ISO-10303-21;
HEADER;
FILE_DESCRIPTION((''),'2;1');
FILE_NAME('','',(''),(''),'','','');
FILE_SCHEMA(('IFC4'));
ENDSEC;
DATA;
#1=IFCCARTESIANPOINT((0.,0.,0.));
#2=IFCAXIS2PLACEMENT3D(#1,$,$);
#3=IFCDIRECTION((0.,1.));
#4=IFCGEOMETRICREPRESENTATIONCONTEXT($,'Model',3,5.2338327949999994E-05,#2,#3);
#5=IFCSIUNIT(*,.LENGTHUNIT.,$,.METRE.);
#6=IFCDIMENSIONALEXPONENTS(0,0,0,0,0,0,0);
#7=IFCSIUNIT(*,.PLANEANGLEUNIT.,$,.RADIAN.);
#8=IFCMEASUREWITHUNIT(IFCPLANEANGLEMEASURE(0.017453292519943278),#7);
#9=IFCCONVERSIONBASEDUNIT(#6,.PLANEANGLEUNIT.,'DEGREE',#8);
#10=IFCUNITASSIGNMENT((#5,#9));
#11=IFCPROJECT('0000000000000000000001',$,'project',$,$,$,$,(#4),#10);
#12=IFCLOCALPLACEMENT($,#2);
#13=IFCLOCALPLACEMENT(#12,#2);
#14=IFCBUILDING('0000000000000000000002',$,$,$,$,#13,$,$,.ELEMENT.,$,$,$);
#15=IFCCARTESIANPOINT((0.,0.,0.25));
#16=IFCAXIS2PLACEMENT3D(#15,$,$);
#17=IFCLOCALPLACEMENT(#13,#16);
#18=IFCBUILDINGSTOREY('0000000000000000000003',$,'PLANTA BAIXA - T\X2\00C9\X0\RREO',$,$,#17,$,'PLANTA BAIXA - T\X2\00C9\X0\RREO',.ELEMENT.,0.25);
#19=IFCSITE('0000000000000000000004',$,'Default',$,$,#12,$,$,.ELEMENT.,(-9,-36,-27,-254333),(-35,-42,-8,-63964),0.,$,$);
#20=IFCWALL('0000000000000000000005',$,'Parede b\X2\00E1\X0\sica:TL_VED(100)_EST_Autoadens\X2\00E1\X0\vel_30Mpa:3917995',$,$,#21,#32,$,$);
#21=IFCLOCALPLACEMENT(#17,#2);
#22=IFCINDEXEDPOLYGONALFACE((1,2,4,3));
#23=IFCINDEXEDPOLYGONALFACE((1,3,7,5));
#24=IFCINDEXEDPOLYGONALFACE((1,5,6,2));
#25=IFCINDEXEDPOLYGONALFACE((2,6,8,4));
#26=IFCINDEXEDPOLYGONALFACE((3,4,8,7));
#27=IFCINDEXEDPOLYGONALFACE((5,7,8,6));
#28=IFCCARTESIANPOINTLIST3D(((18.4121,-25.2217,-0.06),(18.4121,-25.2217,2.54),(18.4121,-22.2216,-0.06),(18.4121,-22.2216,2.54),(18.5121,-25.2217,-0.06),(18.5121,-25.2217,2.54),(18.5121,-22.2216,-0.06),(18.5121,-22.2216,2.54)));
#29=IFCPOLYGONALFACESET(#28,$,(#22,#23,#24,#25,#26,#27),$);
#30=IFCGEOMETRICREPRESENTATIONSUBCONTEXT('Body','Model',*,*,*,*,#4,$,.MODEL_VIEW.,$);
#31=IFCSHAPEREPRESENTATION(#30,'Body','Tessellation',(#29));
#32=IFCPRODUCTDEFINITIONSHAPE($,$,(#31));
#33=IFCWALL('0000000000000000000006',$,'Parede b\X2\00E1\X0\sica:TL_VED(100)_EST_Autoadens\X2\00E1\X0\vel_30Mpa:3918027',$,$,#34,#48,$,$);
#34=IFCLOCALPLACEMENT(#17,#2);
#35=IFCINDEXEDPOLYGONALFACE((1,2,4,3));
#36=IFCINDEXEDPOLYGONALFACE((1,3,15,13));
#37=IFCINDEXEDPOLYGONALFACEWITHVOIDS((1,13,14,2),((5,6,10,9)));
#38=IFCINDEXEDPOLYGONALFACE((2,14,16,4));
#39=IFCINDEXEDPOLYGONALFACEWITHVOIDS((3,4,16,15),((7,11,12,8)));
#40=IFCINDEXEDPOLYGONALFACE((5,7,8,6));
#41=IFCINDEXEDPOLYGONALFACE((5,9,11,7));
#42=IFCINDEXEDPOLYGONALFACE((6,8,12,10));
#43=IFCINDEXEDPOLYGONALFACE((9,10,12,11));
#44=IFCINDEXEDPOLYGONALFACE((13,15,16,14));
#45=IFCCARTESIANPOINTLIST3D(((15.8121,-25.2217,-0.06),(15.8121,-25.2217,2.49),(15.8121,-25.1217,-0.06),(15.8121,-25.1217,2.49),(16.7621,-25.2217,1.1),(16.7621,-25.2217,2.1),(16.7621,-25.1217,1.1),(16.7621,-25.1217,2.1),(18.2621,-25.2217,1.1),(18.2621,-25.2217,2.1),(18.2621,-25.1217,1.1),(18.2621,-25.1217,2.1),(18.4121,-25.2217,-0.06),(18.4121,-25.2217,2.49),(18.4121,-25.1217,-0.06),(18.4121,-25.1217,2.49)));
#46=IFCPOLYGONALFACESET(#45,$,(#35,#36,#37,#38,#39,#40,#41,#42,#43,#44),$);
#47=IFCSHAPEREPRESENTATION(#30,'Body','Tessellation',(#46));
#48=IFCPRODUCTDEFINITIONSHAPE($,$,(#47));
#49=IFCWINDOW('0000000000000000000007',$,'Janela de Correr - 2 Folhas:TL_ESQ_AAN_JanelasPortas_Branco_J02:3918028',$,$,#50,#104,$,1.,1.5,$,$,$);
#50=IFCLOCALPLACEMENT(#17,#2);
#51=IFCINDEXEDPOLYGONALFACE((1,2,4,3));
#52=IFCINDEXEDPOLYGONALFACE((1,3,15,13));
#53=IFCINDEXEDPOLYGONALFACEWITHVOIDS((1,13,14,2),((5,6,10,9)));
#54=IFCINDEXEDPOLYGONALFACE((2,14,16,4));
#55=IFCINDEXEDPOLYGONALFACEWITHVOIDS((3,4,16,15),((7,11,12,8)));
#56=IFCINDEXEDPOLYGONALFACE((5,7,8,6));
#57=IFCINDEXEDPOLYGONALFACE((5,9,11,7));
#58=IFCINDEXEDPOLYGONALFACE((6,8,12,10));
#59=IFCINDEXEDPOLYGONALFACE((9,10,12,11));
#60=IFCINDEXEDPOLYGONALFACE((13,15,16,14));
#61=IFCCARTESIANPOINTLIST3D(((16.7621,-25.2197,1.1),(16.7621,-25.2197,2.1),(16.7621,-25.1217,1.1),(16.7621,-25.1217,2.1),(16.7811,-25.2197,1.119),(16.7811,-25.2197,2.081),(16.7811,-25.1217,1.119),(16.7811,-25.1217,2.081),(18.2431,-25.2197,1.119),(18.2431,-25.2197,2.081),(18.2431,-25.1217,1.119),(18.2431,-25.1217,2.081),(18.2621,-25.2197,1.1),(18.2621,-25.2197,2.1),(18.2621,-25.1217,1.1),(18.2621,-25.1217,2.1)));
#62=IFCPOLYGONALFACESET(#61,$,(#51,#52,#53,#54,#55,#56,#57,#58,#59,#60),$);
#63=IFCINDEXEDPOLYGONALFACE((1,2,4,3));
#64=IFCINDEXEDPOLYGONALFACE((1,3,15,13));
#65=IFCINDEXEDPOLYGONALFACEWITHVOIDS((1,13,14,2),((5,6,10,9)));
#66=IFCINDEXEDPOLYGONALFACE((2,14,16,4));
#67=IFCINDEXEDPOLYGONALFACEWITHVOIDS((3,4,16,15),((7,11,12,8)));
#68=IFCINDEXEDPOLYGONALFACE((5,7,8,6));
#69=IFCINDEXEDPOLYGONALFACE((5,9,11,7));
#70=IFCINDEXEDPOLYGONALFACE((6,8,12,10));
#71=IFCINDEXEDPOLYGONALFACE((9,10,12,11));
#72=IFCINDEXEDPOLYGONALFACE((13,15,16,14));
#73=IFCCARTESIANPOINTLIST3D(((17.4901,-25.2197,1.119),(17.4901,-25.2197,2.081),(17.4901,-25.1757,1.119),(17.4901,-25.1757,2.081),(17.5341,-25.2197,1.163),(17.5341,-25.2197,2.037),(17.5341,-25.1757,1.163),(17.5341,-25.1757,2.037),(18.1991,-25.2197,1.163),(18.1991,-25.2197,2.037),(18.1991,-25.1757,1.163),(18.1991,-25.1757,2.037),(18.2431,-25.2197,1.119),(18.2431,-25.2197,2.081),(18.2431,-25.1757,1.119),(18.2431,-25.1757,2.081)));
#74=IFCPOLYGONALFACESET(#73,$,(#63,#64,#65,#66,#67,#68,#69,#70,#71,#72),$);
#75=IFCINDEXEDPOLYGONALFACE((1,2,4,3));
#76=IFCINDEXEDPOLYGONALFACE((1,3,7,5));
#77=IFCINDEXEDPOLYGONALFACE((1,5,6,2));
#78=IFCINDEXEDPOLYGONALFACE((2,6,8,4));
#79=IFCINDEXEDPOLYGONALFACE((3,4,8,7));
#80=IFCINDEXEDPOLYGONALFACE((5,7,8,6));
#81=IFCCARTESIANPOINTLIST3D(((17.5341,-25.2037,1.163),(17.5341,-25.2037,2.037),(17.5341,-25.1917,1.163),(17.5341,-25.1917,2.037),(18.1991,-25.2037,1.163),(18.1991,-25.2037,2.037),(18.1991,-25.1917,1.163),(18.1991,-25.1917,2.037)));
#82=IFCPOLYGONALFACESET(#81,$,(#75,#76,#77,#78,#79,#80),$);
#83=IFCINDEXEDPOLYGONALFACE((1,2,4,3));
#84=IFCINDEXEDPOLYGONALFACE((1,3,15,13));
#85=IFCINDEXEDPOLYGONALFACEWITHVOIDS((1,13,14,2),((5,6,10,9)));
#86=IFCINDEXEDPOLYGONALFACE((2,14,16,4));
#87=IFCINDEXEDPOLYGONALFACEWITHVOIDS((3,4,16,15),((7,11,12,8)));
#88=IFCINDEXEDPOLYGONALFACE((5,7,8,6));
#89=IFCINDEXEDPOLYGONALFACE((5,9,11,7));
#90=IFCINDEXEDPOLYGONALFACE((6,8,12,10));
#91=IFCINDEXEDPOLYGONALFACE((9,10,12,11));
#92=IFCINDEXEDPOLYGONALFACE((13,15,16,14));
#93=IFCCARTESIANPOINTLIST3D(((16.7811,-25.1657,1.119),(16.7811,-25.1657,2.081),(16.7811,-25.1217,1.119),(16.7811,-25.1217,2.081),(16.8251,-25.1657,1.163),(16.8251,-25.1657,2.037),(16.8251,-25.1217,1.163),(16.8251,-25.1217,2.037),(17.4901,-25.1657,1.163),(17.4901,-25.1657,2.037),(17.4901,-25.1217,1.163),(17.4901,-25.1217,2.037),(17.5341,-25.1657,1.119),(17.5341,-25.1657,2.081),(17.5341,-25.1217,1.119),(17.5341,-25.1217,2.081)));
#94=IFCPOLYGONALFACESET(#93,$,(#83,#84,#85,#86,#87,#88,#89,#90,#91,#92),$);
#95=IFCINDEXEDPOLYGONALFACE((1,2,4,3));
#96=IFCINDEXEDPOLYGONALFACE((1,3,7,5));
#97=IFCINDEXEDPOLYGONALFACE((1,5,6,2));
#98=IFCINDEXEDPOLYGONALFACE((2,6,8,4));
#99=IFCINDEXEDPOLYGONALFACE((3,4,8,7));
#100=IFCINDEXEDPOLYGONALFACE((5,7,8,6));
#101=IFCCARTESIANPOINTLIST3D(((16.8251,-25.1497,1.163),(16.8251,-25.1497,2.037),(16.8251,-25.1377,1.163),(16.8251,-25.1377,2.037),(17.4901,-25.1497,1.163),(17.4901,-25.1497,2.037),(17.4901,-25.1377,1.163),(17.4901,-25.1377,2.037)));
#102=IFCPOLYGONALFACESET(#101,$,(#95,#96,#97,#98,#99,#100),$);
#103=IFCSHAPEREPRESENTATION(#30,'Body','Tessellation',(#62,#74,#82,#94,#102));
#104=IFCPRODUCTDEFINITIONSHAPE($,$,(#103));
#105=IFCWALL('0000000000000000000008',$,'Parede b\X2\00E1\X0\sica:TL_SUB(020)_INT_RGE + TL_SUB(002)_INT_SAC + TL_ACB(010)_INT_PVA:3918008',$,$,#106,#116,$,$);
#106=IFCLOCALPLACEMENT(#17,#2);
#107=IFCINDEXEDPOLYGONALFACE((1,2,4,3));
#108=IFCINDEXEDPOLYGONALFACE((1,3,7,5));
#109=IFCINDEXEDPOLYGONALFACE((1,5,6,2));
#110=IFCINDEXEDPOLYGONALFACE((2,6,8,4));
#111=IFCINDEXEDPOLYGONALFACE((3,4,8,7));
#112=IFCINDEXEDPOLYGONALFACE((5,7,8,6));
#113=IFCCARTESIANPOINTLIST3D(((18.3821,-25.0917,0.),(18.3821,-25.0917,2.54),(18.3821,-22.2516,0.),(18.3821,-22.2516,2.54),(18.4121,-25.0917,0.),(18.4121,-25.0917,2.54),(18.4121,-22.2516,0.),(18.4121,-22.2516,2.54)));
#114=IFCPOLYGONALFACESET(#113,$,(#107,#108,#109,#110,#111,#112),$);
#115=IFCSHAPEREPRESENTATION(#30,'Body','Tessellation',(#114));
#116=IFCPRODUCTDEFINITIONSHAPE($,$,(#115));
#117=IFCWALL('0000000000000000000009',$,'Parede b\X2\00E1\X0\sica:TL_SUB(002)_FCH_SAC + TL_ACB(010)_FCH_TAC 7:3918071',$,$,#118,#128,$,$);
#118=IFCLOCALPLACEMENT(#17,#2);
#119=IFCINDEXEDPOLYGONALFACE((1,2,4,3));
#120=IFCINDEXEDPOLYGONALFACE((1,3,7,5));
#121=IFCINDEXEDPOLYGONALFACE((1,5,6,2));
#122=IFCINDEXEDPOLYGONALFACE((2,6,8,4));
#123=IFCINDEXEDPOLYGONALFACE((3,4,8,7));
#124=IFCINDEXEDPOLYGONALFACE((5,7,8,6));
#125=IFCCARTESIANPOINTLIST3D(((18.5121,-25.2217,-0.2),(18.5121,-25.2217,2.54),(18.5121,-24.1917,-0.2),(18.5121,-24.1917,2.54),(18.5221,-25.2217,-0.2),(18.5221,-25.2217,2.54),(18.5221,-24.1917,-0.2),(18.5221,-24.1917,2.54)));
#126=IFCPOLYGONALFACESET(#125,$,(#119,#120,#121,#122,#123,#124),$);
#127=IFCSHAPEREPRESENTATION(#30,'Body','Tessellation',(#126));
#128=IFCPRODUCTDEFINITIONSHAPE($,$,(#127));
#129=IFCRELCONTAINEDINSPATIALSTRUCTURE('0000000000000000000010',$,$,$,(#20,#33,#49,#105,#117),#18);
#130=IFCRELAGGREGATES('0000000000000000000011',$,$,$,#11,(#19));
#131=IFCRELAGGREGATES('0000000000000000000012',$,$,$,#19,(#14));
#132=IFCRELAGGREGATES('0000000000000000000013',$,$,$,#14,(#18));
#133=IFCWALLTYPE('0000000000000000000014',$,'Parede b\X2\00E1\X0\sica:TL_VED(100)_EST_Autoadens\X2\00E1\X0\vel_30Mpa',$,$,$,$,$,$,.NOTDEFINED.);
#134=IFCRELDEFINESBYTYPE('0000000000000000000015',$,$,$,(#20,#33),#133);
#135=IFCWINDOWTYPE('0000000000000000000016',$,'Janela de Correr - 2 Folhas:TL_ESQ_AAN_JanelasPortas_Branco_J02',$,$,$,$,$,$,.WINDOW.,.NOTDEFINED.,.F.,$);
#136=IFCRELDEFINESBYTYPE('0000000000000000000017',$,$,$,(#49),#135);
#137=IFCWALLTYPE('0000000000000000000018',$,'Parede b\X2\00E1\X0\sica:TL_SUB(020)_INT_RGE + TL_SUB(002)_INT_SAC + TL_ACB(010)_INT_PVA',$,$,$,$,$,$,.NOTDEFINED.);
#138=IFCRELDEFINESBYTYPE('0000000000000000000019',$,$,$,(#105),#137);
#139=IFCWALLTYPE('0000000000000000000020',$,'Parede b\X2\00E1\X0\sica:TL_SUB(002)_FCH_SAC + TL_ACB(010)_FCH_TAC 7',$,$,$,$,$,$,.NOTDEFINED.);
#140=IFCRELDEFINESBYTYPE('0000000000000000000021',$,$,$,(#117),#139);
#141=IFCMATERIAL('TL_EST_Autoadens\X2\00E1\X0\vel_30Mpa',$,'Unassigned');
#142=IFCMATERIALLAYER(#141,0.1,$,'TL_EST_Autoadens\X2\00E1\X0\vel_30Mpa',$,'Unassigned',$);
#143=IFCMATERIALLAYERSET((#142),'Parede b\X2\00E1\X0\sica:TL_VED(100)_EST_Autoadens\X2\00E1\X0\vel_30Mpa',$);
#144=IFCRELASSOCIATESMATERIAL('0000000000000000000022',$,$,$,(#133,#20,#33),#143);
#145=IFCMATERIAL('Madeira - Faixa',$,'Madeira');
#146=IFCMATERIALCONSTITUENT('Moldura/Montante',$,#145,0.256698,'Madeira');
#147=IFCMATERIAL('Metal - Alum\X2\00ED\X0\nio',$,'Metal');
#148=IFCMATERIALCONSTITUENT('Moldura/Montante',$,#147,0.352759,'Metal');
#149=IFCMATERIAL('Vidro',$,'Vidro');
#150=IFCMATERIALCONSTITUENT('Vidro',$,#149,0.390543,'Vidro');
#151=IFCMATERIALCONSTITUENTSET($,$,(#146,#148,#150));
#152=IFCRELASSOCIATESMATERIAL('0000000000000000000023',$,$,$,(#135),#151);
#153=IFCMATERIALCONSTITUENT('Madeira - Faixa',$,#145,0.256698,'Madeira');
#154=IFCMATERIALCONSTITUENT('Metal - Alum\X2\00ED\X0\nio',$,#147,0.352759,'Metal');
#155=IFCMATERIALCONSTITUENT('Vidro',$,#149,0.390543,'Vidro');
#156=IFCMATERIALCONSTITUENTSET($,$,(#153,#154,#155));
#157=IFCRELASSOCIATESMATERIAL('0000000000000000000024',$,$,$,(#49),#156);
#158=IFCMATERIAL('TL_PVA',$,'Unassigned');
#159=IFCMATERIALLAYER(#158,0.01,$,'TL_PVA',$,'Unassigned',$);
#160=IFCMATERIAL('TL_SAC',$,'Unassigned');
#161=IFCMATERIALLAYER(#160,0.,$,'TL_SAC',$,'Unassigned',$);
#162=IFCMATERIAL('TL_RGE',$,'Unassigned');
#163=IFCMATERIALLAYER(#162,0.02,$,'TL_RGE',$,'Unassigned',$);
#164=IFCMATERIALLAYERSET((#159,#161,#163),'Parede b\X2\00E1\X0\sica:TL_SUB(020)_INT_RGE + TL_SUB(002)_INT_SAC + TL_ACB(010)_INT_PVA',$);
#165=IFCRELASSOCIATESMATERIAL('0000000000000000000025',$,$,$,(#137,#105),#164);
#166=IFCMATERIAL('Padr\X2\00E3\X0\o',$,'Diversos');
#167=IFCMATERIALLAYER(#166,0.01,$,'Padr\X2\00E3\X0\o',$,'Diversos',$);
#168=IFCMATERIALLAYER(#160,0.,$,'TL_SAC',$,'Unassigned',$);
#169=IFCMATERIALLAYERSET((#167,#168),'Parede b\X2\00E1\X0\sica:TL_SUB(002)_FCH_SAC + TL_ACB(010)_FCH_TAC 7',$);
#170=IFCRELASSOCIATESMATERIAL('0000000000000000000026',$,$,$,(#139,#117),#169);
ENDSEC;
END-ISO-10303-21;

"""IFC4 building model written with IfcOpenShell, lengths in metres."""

from ifc_helpers import new_model, entity, si_unit, converted_unit, direction, frame, frame_2d, origin, origin_2d_with_axis, place, context, subcontext, project, spatial, polyline, rectangle, outline, extrude, source, transform, mapped, material, layer, layer_set, layer_usage, constituent, constituent_set, type_object, type_shapes, element, fill, save


model = new_model("IFC4")

# Units and contexts
model_context = context("Model", 3, precision=5.2338327949999994e-05, world=origin(), true_north=direction((0.0, 1.0)))
body_context = subcontext(model_context, "Body", "Model", "MODEL_VIEW")
ifc_project = project(units=[si_unit("LENGTHUNIT", "METRE"), converted_unit("PLANEANGLEUNIT", "DEGREE", entity("IfcPlaneAngleMeasure", 0.017453292519943278), si_unit("PLANEANGLEUNIT", "RADIAN"), dimensions=[0, 0, 0, 0, 0, 0, 0])], contexts=[model_context])

# Site, building, storey
site_placement = place(None, frame((0.0, 0.0, 0.0)))
site = spatial("IfcSite", under=ifc_project, at=site_placement, Name="Default", CompositionType="ELEMENT", RefLatitude=(-9, -36, -27, -254333), RefLongitude=(-35, -42, -8, -63964), RefElevation=0.0)
building_placement = place(site_placement, origin())
building = spatial("IfcBuilding", under=site, at=building_placement, CompositionType="ELEMENT")
storey_placement = place(building_placement, frame((0.0, 0.0, 0.25)))
storey = spatial("IfcBuildingStorey", under=building, at=storey_placement, Name="PLANTA BAIXA - TÉRREO", LongName="PLANTA BAIXA - TÉRREO", CompositionType="ELEMENT", Elevation=0.25)

# Wall
ifc_material_1 = material(Name="TL_EST_Autoadensável_30Mpa", Category="Unassigned")
ifc_layer_1 = layer(ifc_material_1, 0.1, Name="TL_EST_Autoadensável_30Mpa", Category="Unassigned")
ifc_layer_set_1 = layer_set([ifc_layer_1], Name="Parede básica:TL_VED(100)_EST_Autoadensável_30Mpa")
ifc_layer_usage_1 = layer_usage(ifc_layer_set_1, "AXIS2", "NEGATIVE", 0.05)
wall_type_1 = type_object("IfcWallType", Name="Parede básica:TL_VED(100)_EST_Autoadensável_30Mpa", PredefinedType="NOTDEFINED", material=ifc_layer_set_1)
wall_1_placement = place(storey_placement, frame((18.4621, -25.2217, -0.06), z_axis=(0.0, 0.0, 1.0), x_axis=(0.0, 1.0, 0.0)))
element("IfcWall", 1, at=wall_1_placement, inside=storey, type_object=wall_type_1, material=ifc_layer_usage_1, Name="Parede básica:TL_VED(100)_EST_Autoadensável_30Mpa:3917995", context=body_context, shape_type="SweptSolid", body=[
    extrude(rectangle(XDim=3.0001, YDim=0.1, at=frame_2d((1.5001, 0.0), x_axis=(-1.0, 0.0))), origin(), (0.0, 0.0, 1.0), 2.6),
])

# Wall, opening, window
ifc_layer_usage_2 = layer_usage(ifc_layer_set_1, "AXIS2", "NEGATIVE", 0.05)
wall_2_placement = place(storey_placement, frame((18.4121, -25.1717, -0.06), z_axis=(0.0, 0.0, 1.0), x_axis=(-1.0, 0.0, 0.0)))
wall_2 = element("IfcWall", 2, at=wall_2_placement, inside=storey, type_object=wall_type_1, material=ifc_layer_usage_2, Name="Parede básica:TL_VED(100)_EST_Autoadensável_30Mpa:3918027", context=body_context, shape_type="SweptSolid", body=[
    extrude(rectangle(XDim=2.6, YDim=0.1, at=frame_2d((1.3, 0.0), x_axis=(-1.0, 0.0))), origin(), (0.0, 0.0, 1.0), 2.55),
])
opening_placement = place(wall_2_placement, frame((0.15, -0.05, 1.16)))
opening = element("IfcOpeningElement", 3, at=opening_placement, cuts=wall_2, PredefinedType="OPENING", context=body_context, shape_type="SweptSolid", body=[
    extrude(rectangle(XDim=1.0, YDim=1.5, at=frame_2d((0.5, 0.75), x_axis=(-1.0, 0.0))), frame((0.0, 0.0, 0.0), z_axis=(0.0, 1.0, 0.0), x_axis=(0.0, 0.0, 1.0)), (0.0, 0.0, 1.0), 0.1),
])
ifc_material_2 = material(Name="Madeira - Faixa", Category="Madeira")
ifc_constituent_1 = constituent(ifc_material_2, Name="Madeira - Faixa", Category="Madeira", fraction=0.256698)
ifc_material_3 = material(Name="Metal - Alumínio", Category="Metal")
ifc_constituent_2 = constituent(ifc_material_3, Name="Metal - Alumínio", Category="Metal", fraction=0.352759)
ifc_material_4 = material(Name="Vidro", Category="Vidro")
ifc_constituent_3 = constituent(ifc_material_4, Name="Vidro", Category="Vidro", fraction=0.390543)
ifc_constituent_set_1 = constituent_set(constituents=[ifc_constituent_1, ifc_constituent_2, ifc_constituent_3])
ifc_constituent_4 = constituent(ifc_material_2, Name="Moldura/Montante", Category="Madeira", fraction=0.256698)
ifc_constituent_5 = constituent(ifc_material_3, Name="Moldura/Montante", Category="Metal", fraction=0.352759)
ifc_constituent_6 = constituent(ifc_material_4, Name="Vidro", Category="Vidro", fraction=0.390543)
ifc_constituent_set_2 = constituent_set(constituents=[ifc_constituent_4, ifc_constituent_5, ifc_constituent_6])
window_type = type_object("IfcWindowType", Name="Janela de Correr - 2 Folhas:TL_ESQ_AAN_JanelasPortas_Branco_J02", ParameterTakesPrecedence=False, PartitioningType="NOTDEFINED", PredefinedType="WINDOW", material=ifc_constituent_set_2)
shared_shape_1 = source(origin(), body_context, "Body", "SweptSolid", [
    extrude(outline(polyline([(-0.75, -0.5), (0.75, -0.5), (0.75, 0.5), (-0.75, 0.5), (-0.75, -0.5)]), holes=[polyline([(-0.731, -0.481), (-0.731, 0.481), (0.731, 0.481), (0.731, -0.481), (-0.731, -0.481)])]), frame((0.75, 0.124, 0.5), z_axis=(0.0, -1.0, 0.0), x_axis=(-1.0, 0.0, 0.0)), (0.0, 0.0, 1.0), 0.098),
    extrude(outline(polyline([(-0.3765, -0.481), (0.3765, -0.481), (0.3765, 0.481), (-0.3765, 0.481), (-0.3765, -0.481)]), holes=[polyline([(-0.3325, -0.437), (-0.3325, 0.437), (0.3325, 0.437), (0.3325, -0.437), (-0.3325, -0.437)])]), frame((0.3955, 0.124, 0.5), z_axis=(0.0, -1.0, 0.0), x_axis=(-1.0, 0.0, 0.0)), (0.0, 0.0, 1.0), 0.044),
    extrude(rectangle(XDim=0.665, YDim=0.012, at=origin_2d_with_axis()), frame((0.3955, 0.102, 0.063), z_axis=(0.0, 0.0, 1.0), x_axis=(-1.0, 0.0, 0.0)), (0.0, 0.0, 1.0), 0.874),
    extrude(outline(polyline([(-0.481, -0.3765), (0.481, -0.3765), (0.481, 0.3765), (-0.481, 0.3765), (-0.481, -0.3765)]), holes=[polyline([(-0.437, -0.3325), (-0.437, 0.3325), (0.437, 0.3325), (0.437, -0.3325), (-0.437, -0.3325)])]), frame((1.1045, 0.07, 0.5), z_axis=(0.0, -1.0, 0.0), x_axis=(0.0, 0.0, -1.0)), (0.0, 0.0, 1.0), 0.044),
    extrude(rectangle(XDim=0.665, YDim=0.012, at=origin_2d_with_axis()), frame((1.1045, 0.048, 0.063), z_axis=(0.0, 0.0, 1.0), x_axis=(-1.0, 0.0, 0.0)), (0.0, 0.0, 1.0), 0.874),
])
type_shapes(window_type, [shared_shape_1])
window_placement = place(opening_placement, frame((0.0, -0.026, 0.0)))
window = element("IfcWindow", 4, at=window_placement, inside=storey, type_object=window_type, material=ifc_constituent_set_1, Name="Janela de Correr - 2 Folhas:TL_ESQ_AAN_JanelasPortas_Branco_J02:3918028", OverallHeight=1.0, OverallWidth=1.5, context=body_context, shape_type="MappedRepresentation", body=[
    mapped(shared_shape_1, transform((0.0, 0.0, 0.0), scale=1.0)),
])
fill(opening, window)

# Walls
ifc_material_5 = material(Name="TL_PVA", Category="Unassigned")
ifc_layer_2 = layer(ifc_material_5, 0.01, Name="TL_PVA", Category="Unassigned")
ifc_material_6 = material(Name="TL_SAC", Category="Unassigned")
ifc_layer_3 = layer(ifc_material_6, 0.0, Name="TL_SAC", Category="Unassigned")
ifc_material_7 = material(Name="TL_RGE", Category="Unassigned")
ifc_layer_4 = layer(ifc_material_7, 0.02, Name="TL_RGE", Category="Unassigned")
ifc_layer_set_2 = layer_set([ifc_layer_2, ifc_layer_3, ifc_layer_4], Name="Parede básica:TL_SUB(020)_INT_RGE + TL_SUB(002)_INT_SAC + TL_ACB(010)_INT_PVA")
ifc_layer_usage_3 = layer_usage(ifc_layer_set_2, "AXIS2", "NEGATIVE", 0.015)
wall_type_2 = type_object("IfcWallType", Name="Parede básica:TL_SUB(020)_INT_RGE + TL_SUB(002)_INT_SAC + TL_ACB(010)_INT_PVA", PredefinedType="NOTDEFINED", material=ifc_layer_set_2)
wall_3_placement = place(storey_placement, frame((18.3971, -25.0917, 0.0), z_axis=(0.0, 0.0, 1.0), x_axis=(0.0, 1.0, 0.0)))
element("IfcWall", 5, at=wall_3_placement, inside=storey, type_object=wall_type_2, material=ifc_layer_usage_3, Name="Parede básica:TL_SUB(020)_INT_RGE + TL_SUB(002)_INT_SAC + TL_ACB(010)_INT_PVA:3918008", context=body_context, shape_type="SweptSolid", body=[
    extrude(rectangle(XDim=2.8401, YDim=0.03, at=frame_2d((1.4201, 0.0), x_axis=(-1.0, 0.0))), origin(), (0.0, 0.0, 1.0), 2.54),
])
ifc_material_8 = material(Name="Padrão", Category="Diversos")
ifc_layer_5 = layer(ifc_material_8, 0.01, Name="Padrão", Category="Diversos")
ifc_layer_6 = layer(ifc_material_6, 0.0, Name="TL_SAC", Category="Unassigned")
ifc_layer_set_3 = layer_set([ifc_layer_5, ifc_layer_6], Name="Parede básica:TL_SUB(002)_FCH_SAC + TL_ACB(010)_FCH_TAC 7")
ifc_layer_usage_4 = layer_usage(ifc_layer_set_3, "AXIS2", "NEGATIVE", 0.005)
wall_type_3 = type_object("IfcWallType", Name="Parede básica:TL_SUB(002)_FCH_SAC + TL_ACB(010)_FCH_TAC 7", PredefinedType="NOTDEFINED", material=ifc_layer_set_3)
wall_4_placement = place(storey_placement, frame((18.5171, -25.2217, -0.2), z_axis=(0.0, 0.0, 1.0), x_axis=(0.0, 1.0, 0.0)))
element("IfcWall", 6, at=wall_4_placement, inside=storey, type_object=wall_type_3, material=ifc_layer_usage_4, Name="Parede básica:TL_SUB(002)_FCH_SAC + TL_ACB(010)_FCH_TAC 7:3918071", context=body_context, shape_type="SweptSolid", body=[
    extrude(rectangle(XDim=1.03, YDim=0.01, at=frame_2d((0.515, 0.0), x_axis=(-1.0, 0.0))), origin(), (0.0, 0.0, 1.0), 2.74),
])

save(model, "model.ifc")
